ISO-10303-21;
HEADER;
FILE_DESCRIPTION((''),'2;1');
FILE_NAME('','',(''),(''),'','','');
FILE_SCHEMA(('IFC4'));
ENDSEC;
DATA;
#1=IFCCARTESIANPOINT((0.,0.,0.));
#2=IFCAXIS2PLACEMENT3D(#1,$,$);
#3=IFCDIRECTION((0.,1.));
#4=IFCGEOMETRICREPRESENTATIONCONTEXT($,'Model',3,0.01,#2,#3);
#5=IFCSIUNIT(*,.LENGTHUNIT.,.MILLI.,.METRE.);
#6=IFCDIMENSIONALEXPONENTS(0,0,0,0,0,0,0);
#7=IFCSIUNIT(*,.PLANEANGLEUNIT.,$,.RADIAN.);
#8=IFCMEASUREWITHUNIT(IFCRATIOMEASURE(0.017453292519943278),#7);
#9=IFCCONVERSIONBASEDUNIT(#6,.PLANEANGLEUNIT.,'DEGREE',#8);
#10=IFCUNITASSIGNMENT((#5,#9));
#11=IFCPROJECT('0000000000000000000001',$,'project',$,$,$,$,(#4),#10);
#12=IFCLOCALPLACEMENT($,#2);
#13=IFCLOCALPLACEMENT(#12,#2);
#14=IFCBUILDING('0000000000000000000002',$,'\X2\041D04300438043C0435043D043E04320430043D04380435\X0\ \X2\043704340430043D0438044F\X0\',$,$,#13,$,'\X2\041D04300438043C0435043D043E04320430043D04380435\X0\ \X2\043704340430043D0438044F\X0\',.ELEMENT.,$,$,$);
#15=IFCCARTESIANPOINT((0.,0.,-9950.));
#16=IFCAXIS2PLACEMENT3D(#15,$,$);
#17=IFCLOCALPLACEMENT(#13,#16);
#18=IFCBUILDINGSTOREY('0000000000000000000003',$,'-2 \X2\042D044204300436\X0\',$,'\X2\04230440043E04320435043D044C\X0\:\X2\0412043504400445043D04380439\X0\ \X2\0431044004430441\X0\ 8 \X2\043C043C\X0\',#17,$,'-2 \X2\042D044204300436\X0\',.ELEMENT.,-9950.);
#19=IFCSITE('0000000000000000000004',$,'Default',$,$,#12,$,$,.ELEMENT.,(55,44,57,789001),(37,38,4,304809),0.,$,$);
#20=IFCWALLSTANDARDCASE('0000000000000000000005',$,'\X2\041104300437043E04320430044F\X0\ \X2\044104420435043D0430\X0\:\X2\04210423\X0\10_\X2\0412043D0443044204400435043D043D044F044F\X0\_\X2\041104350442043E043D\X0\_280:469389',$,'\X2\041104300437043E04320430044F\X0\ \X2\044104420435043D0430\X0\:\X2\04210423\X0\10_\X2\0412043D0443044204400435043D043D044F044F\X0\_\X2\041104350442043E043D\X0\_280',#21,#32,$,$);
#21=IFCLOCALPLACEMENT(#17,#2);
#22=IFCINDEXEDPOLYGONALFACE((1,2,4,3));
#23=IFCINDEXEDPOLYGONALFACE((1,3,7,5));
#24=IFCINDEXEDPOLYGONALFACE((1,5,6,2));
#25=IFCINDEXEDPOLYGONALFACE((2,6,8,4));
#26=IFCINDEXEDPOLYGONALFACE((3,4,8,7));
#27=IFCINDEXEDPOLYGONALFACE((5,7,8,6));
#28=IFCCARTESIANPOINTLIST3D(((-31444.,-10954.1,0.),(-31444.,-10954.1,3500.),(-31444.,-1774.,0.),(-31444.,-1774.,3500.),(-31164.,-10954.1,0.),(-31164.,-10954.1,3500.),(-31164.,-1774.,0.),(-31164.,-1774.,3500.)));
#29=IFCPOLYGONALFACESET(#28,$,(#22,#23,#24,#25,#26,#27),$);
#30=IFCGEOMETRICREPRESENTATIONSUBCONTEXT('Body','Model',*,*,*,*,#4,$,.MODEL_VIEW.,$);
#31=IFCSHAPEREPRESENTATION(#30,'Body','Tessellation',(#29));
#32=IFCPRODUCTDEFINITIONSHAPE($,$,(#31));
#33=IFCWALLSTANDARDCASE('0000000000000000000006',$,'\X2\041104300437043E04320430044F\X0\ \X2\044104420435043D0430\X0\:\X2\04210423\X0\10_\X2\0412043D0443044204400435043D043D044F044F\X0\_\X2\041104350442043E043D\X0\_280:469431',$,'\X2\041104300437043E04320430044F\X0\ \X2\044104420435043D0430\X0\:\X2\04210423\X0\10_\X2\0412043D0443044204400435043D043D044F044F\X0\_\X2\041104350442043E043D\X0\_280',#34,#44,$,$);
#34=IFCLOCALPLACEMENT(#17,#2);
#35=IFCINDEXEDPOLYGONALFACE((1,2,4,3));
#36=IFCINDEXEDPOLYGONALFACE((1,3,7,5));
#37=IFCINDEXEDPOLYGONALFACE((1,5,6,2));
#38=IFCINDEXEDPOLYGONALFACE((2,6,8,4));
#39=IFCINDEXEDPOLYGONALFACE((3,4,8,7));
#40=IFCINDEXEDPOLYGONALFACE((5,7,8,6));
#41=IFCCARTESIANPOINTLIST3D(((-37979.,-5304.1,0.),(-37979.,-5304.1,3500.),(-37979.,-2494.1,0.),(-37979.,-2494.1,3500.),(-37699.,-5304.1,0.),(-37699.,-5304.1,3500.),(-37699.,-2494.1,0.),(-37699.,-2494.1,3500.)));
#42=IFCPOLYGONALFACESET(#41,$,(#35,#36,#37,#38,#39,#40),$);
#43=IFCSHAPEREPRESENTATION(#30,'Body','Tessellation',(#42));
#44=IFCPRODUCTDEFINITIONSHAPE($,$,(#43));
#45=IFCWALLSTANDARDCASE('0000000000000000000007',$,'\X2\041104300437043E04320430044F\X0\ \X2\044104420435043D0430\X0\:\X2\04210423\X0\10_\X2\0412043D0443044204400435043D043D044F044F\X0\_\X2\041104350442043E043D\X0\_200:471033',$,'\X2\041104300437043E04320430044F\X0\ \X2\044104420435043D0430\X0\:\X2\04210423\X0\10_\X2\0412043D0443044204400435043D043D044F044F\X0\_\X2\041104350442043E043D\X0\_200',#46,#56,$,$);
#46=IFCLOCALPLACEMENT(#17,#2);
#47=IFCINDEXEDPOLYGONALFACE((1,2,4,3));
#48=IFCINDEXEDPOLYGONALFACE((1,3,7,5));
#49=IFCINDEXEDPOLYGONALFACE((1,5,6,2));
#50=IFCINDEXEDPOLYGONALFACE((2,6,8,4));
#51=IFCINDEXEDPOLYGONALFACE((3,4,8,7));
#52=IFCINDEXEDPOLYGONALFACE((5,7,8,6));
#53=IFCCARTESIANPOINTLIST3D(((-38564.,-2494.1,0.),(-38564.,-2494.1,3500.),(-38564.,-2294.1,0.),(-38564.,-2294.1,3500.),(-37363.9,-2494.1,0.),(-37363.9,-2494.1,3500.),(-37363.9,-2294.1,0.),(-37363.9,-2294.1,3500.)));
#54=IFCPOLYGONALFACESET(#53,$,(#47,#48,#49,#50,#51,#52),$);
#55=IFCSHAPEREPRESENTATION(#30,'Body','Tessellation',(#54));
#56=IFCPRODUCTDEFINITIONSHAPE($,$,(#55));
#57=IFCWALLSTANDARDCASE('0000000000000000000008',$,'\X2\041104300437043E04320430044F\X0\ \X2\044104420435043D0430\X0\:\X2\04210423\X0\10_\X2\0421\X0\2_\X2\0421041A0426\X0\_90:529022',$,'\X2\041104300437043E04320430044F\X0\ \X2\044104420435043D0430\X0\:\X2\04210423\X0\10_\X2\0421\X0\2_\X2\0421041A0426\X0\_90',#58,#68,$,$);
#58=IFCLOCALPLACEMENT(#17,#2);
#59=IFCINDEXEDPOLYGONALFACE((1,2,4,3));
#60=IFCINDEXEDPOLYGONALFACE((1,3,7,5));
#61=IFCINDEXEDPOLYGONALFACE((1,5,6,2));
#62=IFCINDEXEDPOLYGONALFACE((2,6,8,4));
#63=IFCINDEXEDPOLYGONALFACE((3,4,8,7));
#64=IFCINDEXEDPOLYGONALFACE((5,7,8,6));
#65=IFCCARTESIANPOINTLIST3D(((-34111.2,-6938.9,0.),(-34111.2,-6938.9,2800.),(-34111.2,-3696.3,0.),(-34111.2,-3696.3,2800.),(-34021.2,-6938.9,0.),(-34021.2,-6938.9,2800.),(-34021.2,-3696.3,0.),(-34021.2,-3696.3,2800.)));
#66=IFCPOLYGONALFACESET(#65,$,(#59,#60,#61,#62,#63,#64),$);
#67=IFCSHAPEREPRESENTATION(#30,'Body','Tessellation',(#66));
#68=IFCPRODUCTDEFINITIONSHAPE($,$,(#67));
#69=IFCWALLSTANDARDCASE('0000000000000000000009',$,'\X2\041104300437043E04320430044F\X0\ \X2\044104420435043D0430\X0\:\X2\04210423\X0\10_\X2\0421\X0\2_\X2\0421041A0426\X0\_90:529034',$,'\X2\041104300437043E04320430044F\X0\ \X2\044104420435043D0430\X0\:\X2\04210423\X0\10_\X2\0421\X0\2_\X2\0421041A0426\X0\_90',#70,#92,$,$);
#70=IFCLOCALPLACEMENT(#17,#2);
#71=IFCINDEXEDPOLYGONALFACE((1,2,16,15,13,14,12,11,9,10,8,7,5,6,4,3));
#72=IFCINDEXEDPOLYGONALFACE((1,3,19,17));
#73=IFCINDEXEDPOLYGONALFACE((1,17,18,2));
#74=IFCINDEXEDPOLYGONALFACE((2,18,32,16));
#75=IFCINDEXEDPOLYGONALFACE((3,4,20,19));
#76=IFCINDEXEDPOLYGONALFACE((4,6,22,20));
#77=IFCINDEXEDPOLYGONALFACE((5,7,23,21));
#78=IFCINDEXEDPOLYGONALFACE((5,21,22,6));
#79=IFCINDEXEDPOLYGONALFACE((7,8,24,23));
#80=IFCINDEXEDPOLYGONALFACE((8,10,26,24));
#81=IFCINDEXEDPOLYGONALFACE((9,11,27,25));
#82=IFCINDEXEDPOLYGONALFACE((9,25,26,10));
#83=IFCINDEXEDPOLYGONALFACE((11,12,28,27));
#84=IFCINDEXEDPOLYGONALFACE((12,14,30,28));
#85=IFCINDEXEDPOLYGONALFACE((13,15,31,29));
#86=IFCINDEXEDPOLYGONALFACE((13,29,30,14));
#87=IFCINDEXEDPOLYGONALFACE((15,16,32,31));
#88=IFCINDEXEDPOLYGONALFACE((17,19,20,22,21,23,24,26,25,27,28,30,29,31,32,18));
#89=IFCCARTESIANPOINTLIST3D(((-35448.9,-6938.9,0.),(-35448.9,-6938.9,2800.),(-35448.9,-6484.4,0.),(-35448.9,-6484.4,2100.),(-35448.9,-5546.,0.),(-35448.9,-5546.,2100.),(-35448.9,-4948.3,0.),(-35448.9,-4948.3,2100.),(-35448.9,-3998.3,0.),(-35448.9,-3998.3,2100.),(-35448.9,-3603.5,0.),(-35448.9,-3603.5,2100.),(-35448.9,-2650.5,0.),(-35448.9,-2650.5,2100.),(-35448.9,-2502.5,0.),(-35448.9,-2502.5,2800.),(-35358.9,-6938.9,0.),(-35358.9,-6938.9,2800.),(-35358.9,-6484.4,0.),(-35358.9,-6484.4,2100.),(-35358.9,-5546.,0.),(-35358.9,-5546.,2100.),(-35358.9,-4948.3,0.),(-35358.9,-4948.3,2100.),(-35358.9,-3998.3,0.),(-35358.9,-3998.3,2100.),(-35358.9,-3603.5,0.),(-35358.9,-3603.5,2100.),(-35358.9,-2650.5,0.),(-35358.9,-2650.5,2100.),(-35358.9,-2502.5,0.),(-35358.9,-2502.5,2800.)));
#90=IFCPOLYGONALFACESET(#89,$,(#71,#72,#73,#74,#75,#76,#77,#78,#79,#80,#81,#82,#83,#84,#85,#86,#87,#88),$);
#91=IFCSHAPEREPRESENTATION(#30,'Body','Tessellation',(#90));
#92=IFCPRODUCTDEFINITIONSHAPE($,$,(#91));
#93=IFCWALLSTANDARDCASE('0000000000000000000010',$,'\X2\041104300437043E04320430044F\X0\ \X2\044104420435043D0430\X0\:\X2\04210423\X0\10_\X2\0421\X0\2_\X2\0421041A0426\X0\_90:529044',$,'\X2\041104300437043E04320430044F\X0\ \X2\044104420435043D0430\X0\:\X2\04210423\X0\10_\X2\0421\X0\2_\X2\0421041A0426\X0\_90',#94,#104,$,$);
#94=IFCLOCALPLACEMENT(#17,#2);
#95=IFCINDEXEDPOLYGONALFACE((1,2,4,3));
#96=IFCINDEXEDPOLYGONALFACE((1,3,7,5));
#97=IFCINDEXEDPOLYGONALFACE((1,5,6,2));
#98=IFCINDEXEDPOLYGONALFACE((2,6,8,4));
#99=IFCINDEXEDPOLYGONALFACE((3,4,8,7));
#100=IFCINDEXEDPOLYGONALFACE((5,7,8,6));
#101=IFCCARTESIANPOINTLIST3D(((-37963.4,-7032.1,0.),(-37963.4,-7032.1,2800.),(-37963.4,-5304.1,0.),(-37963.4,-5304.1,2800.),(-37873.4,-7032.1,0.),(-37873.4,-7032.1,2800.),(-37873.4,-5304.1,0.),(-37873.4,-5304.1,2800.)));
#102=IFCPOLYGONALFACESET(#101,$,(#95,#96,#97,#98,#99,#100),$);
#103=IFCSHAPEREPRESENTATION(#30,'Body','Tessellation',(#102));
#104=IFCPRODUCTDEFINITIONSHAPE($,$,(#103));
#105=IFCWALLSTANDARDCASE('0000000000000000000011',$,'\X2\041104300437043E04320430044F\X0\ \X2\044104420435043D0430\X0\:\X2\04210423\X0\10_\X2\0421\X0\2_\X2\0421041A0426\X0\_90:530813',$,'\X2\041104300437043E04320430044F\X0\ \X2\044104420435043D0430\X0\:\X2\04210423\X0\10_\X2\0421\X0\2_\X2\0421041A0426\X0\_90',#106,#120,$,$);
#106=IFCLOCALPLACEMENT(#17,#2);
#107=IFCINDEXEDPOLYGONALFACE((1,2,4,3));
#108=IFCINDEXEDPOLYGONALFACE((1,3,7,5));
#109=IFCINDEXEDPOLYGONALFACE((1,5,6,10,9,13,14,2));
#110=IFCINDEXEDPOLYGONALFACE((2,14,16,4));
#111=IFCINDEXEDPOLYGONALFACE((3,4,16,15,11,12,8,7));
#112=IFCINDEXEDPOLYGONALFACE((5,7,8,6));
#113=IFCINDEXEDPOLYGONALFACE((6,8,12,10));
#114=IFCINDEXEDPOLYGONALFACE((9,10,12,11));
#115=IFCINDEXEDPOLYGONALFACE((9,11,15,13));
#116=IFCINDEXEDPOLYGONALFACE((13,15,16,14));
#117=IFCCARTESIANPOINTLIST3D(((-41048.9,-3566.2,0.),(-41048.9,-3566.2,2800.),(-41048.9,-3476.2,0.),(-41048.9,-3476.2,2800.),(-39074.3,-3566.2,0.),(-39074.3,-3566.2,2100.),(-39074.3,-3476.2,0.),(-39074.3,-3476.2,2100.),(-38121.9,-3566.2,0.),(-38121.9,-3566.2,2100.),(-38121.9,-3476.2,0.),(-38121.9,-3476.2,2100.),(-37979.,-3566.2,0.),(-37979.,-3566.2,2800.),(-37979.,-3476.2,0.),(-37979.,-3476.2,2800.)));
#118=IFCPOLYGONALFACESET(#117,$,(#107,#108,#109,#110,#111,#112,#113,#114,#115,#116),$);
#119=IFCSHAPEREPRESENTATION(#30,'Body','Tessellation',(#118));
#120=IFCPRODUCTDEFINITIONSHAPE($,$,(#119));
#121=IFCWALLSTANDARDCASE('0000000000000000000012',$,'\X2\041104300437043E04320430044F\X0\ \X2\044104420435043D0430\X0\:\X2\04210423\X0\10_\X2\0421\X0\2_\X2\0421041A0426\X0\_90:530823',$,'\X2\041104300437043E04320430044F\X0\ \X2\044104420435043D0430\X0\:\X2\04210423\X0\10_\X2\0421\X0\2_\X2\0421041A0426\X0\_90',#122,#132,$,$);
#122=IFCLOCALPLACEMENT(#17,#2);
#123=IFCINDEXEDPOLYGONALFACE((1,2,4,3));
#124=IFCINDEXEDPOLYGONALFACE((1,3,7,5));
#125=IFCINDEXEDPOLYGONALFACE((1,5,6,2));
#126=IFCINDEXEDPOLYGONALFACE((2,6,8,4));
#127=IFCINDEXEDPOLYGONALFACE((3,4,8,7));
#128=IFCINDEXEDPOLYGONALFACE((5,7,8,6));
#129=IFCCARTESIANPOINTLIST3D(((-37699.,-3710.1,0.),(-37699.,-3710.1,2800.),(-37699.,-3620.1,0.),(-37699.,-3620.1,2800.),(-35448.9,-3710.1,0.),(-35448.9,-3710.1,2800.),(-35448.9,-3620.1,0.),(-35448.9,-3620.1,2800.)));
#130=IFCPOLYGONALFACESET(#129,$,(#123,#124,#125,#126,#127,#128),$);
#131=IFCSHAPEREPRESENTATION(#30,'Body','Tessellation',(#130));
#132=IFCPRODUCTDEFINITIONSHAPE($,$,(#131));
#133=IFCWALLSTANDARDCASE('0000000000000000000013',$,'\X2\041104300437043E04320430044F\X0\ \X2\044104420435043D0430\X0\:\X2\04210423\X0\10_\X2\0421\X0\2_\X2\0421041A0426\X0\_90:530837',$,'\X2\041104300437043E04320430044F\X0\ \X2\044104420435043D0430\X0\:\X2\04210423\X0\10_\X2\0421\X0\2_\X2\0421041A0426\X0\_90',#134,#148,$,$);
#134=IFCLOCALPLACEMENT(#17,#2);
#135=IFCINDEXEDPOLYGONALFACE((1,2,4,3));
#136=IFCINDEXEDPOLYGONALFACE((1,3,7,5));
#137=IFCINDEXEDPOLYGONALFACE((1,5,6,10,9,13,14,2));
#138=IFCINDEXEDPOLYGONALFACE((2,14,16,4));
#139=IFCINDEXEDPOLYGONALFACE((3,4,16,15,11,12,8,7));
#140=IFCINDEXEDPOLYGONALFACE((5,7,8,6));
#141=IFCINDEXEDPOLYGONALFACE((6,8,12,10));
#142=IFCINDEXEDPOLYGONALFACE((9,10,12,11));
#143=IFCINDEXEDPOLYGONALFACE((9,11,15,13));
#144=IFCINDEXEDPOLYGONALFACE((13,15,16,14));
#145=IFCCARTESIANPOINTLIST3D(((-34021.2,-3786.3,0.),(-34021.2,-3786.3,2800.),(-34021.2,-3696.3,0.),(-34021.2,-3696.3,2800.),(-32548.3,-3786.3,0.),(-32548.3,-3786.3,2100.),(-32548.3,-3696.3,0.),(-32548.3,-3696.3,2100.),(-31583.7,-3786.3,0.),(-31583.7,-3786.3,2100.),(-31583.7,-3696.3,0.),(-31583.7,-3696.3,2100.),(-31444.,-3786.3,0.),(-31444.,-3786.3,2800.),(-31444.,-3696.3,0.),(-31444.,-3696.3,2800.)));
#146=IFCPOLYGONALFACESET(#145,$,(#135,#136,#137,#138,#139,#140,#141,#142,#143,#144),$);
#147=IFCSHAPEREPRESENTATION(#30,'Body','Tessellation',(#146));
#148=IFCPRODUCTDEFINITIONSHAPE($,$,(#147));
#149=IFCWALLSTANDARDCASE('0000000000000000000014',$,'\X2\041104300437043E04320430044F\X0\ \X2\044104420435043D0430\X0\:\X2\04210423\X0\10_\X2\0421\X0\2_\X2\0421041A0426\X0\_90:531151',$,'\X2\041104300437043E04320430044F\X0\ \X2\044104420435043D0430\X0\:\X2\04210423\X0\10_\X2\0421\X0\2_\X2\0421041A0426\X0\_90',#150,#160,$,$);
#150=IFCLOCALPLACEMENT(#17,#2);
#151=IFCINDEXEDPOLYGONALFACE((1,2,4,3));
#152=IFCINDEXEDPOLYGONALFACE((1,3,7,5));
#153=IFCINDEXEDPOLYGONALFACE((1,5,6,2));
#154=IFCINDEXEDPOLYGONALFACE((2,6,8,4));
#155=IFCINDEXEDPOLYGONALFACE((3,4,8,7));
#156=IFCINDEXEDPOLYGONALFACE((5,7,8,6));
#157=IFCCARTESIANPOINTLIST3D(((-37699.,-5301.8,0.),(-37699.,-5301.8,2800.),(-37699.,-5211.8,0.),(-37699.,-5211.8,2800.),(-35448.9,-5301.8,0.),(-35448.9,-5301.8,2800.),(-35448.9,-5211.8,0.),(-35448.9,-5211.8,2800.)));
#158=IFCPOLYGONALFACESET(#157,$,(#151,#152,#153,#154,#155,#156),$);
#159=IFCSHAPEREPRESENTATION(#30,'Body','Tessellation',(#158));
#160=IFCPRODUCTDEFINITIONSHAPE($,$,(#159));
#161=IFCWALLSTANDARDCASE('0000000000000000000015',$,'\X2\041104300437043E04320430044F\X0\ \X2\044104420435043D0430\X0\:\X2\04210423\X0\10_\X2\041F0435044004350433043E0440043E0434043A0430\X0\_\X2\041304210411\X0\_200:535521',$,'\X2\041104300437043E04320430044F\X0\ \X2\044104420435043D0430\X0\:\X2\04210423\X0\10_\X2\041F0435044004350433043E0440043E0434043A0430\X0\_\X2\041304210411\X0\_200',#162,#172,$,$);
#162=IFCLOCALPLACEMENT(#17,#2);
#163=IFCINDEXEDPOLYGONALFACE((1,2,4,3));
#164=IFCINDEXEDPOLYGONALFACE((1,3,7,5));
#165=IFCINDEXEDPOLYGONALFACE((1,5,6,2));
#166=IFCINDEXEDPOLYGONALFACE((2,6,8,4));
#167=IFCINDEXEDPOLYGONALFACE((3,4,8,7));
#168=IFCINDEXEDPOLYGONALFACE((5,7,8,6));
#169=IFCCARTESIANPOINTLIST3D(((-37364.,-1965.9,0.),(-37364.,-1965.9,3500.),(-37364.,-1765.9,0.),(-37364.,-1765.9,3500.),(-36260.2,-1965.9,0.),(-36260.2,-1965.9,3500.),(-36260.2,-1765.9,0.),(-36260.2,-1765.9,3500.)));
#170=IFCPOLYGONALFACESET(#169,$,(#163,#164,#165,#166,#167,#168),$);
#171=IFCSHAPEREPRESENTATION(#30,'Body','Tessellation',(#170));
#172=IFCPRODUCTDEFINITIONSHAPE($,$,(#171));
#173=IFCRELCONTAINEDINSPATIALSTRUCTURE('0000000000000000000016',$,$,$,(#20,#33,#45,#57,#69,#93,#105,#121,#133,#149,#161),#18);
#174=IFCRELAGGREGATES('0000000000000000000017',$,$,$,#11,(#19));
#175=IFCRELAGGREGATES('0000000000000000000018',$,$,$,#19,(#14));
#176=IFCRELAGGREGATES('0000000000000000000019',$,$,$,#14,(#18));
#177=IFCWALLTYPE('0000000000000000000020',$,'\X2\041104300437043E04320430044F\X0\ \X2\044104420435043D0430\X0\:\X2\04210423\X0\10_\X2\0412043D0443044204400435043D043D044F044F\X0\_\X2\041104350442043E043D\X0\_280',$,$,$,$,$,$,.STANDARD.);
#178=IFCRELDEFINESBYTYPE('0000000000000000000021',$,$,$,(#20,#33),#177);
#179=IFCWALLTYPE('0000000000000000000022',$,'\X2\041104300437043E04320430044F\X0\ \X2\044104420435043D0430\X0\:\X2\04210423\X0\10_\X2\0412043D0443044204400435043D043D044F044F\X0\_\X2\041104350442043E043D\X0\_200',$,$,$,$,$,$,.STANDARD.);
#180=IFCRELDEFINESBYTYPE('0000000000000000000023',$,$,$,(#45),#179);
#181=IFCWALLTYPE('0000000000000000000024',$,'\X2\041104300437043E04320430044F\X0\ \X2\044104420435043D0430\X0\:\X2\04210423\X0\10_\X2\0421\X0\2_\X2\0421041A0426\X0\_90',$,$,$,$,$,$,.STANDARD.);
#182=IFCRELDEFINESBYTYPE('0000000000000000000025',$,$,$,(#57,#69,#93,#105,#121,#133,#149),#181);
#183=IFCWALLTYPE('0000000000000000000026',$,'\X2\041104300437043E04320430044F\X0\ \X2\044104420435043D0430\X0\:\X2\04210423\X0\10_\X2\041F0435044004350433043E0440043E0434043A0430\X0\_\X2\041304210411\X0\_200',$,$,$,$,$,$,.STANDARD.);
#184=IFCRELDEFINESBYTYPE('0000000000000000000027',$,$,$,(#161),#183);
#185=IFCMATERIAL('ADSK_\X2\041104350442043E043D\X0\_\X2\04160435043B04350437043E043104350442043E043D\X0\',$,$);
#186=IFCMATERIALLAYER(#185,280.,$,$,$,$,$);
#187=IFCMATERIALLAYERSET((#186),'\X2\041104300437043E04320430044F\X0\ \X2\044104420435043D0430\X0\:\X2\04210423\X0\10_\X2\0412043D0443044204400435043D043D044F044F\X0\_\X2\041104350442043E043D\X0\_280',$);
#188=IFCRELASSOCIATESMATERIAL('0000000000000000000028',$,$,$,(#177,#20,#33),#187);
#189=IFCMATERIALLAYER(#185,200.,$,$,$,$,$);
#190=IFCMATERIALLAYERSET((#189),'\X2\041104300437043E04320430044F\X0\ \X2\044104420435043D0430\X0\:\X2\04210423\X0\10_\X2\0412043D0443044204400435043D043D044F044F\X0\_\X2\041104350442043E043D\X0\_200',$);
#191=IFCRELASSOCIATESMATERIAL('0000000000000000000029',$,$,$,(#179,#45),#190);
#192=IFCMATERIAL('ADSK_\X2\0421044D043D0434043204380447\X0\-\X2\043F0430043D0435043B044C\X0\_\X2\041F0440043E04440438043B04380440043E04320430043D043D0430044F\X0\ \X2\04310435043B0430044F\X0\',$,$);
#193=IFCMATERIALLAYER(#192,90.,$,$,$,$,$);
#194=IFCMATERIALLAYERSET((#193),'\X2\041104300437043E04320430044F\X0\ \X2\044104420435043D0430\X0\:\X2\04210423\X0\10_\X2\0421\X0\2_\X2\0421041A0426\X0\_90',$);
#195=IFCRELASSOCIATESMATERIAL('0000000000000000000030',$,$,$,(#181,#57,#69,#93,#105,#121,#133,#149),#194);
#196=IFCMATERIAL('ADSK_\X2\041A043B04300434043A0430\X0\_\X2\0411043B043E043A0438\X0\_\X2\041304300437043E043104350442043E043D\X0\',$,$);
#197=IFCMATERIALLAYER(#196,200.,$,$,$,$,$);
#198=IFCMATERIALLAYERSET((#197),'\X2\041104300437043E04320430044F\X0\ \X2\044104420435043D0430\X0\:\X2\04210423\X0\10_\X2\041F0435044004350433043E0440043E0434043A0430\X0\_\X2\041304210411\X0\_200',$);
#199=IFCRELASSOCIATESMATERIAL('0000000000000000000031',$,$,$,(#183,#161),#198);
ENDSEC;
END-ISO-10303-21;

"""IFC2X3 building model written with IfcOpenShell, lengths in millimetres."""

from ifc_helpers import new_model, entity, si_unit, converted_unit, direction, frame, frame_2d, origin, place, context, subcontext, project, spatial, rectangle, extrude, material, layer, layer_set, layer_usage, type_object, element, save


model = new_model("IFC2X3")

# Units and contexts
model_context = context("Model", 3, precision=0.01, world=origin(), true_north=direction((0.0, 1.0)))
body_context = subcontext(model_context, "Body", "Model", "MODEL_VIEW")
ifc_project = project(units=[si_unit("LENGTHUNIT", "METRE", prefix="MILLI"), converted_unit("PLANEANGLEUNIT", "DEGREE", entity("IfcRatioMeasure", 0.017453292519943278), si_unit("PLANEANGLEUNIT", "RADIAN"), dimensions=[0, 0, 0, 0, 0, 0, 0])], contexts=[model_context])

# Site, building, storey
site_placement = place(None, origin())
site = spatial("IfcSite", under=ifc_project, at=site_placement, Name="Default", CompositionType="ELEMENT", RefLatitude=(55, 44, 57, 789001), RefLongitude=(37, 38, 4, 304809), RefElevation=0.0)
building_placement = place(site_placement, origin())
building = spatial("IfcBuilding", under=site, at=building_placement, Name="Наименование здания", LongName="Наименование здания", CompositionType="ELEMENT")
storey_placement = place(building_placement, frame((0.0, 0.0, -9950.0)))
storey = spatial("IfcBuildingStorey", under=building, at=storey_placement, Name="-2 Этаж", ObjectType="Уровень:Верхний брус 8 мм", LongName="-2 Этаж", CompositionType="ELEMENT", Elevation=-9950.0)

# Walls
ifc_material_1 = material(Name="ADSK_Бетон_Железобетон")
ifc_layer_1 = layer(ifc_material_1, 280.0)
ifc_layer_set_1 = layer_set([ifc_layer_1], Name="Базовая стена:СУ10_Внутренняя_Бетон_280")
ifc_layer_usage_1 = layer_usage(ifc_layer_set_1, "AXIS2", "NEGATIVE", 140.0)
wall_type_1 = type_object("IfcWallType", Name="Базовая стена:СУ10_Внутренняя_Бетон_280", PredefinedType="STANDARD", material=ifc_layer_set_1)
wall_1_placement = place(storey_placement, frame((-31304.0, -1774.0, 0.0), z_axis=(0.0, 0.0, 1.0), x_axis=(0.0, -1.0, 0.0)))
element("IfcWallStandardCase", 1, at=wall_1_placement, inside=storey, type_object=wall_type_1, material=ifc_layer_usage_1, Name="Базовая стена:СУ10_Внутренняя_Бетон_280:469389", ObjectType="Базовая стена:СУ10_Внутренняя_Бетон_280", context=body_context, shape_type="SweptSolid", body=[
    extrude(rectangle(XDim=9180.0, YDim=280.0, at=frame_2d((4590.0, 0.0), x_axis=(-1.0, 0.0))), origin(), (0.0, 0.0, 1.0), 3500.0),
])
wall_2_placement = place(storey_placement, frame((-37839.0, -2494.1, 0.0), z_axis=(0.0, 0.0, 1.0), x_axis=(0.0, -1.0, 0.0)))
element("IfcWallStandardCase", 2, at=wall_2_placement, inside=storey, type_object=wall_type_1, material=ifc_layer_usage_1, Name="Базовая стена:СУ10_Внутренняя_Бетон_280:469431", ObjectType="Базовая стена:СУ10_Внутренняя_Бетон_280", context=body_context, shape_type="SweptSolid", body=[
    extrude(rectangle(XDim=2810.0, YDim=280.0, at=frame_2d((1405.0, 0.0), x_axis=(-1.0, 0.0))), origin(), (0.0, 0.0, 1.0), 3500.0),
])
ifc_layer_2 = layer(ifc_material_1, 200.0)
ifc_layer_set_2 = layer_set([ifc_layer_2], Name="Базовая стена:СУ10_Внутренняя_Бетон_200")
ifc_layer_usage_2 = layer_usage(ifc_layer_set_2, "AXIS2", "NEGATIVE", 100.0)
wall_type_2 = type_object("IfcWallType", Name="Базовая стена:СУ10_Внутренняя_Бетон_200", PredefinedType="STANDARD", material=ifc_layer_set_2)
wall_3_placement = place(storey_placement, frame((-37363.9, -2394.1, 0.0), z_axis=(0.0, 0.0, 1.0), x_axis=(-1.0, 0.0, 0.0)))
element("IfcWallStandardCase", 3, at=wall_3_placement, inside=storey, type_object=wall_type_2, material=ifc_layer_usage_2, Name="Базовая стена:СУ10_Внутренняя_Бетон_200:471033", ObjectType="Базовая стена:СУ10_Внутренняя_Бетон_200", context=body_context, shape_type="SweptSolid", body=[
    extrude(rectangle(XDim=1200.1, YDim=200.0, at=frame_2d((600.1, 0.0), x_axis=(-1.0, 0.0))), origin(), (0.0, 0.0, 1.0), 3500.0),
])
ifc_material_2 = material(Name="ADSK_Сэндвич-панель_Профилированная белая")
ifc_layer_3 = layer(ifc_material_2, 90.0)
ifc_layer_set_3 = layer_set([ifc_layer_3], Name="Базовая стена:СУ10_С2_СКЦ_90")
ifc_layer_usage_3 = layer_usage(ifc_layer_set_3, "AXIS2", "NEGATIVE", 45.0)
wall_type_3 = type_object("IfcWallType", Name="Базовая стена:СУ10_С2_СКЦ_90", PredefinedType="STANDARD", material=ifc_layer_set_3)
wall_4_placement = place(storey_placement, frame((-34066.2, -3696.3, 0.0), z_axis=(0.0, 0.0, 1.0), x_axis=(0.0, -1.0, 0.0)))
element("IfcWallStandardCase", 4, at=wall_4_placement, inside=storey, type_object=wall_type_3, material=ifc_layer_usage_3, Name="Базовая стена:СУ10_С2_СКЦ_90:529022", ObjectType="Базовая стена:СУ10_С2_СКЦ_90", context=body_context, shape_type="SweptSolid", body=[
    extrude(rectangle(XDim=3242.6, YDim=90.0, at=frame_2d((1621.3, 0.0), x_axis=(-1.0, 0.0))), origin(), (0.0, 0.0, 1.0), 2800.0),
])

# Wall, openings
wall_5_placement = place(storey_placement, frame((-35403.9, -2502.5, 0.0), z_axis=(0.0, 0.0, 1.0), x_axis=(0.0, -1.0, 0.0)))
wall_5 = element("IfcWallStandardCase", 5, at=wall_5_placement, inside=storey, type_object=wall_type_3, material=ifc_layer_usage_3, Name="Базовая стена:СУ10_С2_СКЦ_90:529034", ObjectType="Базовая стена:СУ10_С2_СКЦ_90", context=body_context, shape_type="SweptSolid", body=[
    extrude(rectangle(XDim=4436.4, YDim=90.0, at=frame_2d((2218.2, 0.0), x_axis=(1.0, 0.0))), origin(), (0.0, 0.0, 1.0), 2800.0),
])
opening_1_placement = place(wall_5_placement, origin())
element("IfcOpeningElement", 6, at=opening_1_placement, cuts=wall_5, ObjectType="Opening", context=body_context, shape_type="SweptSolid", body=[
    extrude(rectangle(XDim=2100.0, YDim=953.0, at=frame_2d((0.0, 0.0), x_axis=(1.0, 0.0))), frame((624.5, -45.0, 1050.0), z_axis=(0.0, 1.0, 0.0), x_axis=(0.0, 0.0, -1.0)), (0.0, 0.0, 1.0), 90.0),
])
opening_2_placement = place(wall_5_placement, origin())
element("IfcOpeningElement", 7, at=opening_2_placement, cuts=wall_5, ObjectType="Opening", context=body_context, shape_type="SweptSolid", body=[
    extrude(rectangle(XDim=2100.0, YDim=950.0, at=frame_2d((0.0, 0.0), x_axis=(1.0, 0.0))), frame((1970.7, -45.0, 1050.0), z_axis=(0.0, 1.0, 0.0), x_axis=(0.0, 0.0, -1.0)), (0.0, 0.0, 1.0), 90.0),
])
opening_3_placement = place(wall_5_placement, origin())
element("IfcOpeningElement", 8, at=opening_3_placement, cuts=wall_5, ObjectType="Opening", context=body_context, shape_type="SweptSolid", body=[
    extrude(rectangle(XDim=2100.0, YDim=938.5, at=frame_2d((0.0, 0.0), x_axis=(1.0, 0.0))), frame((3512.7, -45.0, 1050.0), z_axis=(0.0, 1.0, 0.0), x_axis=(0.0, 0.0, -1.0)), (0.0, 0.0, 1.0), 90.0),
])

# Wall
wall_6_placement = place(storey_placement, frame((-37918.4, -5304.1, 0.0), z_axis=(0.0, 0.0, 1.0), x_axis=(0.0, -1.0, 0.0)))
element("IfcWallStandardCase", 9, at=wall_6_placement, inside=storey, type_object=wall_type_3, material=ifc_layer_usage_3, Name="Базовая стена:СУ10_С2_СКЦ_90:529044", ObjectType="Базовая стена:СУ10_С2_СКЦ_90", context=body_context, shape_type="SweptSolid", body=[
    extrude(rectangle(XDim=1728.0, YDim=90.0, at=frame_2d((864.0, 0.0), x_axis=(-1.0, 0.0))), origin(), (0.0, 0.0, 1.0), 2800.0),
])

# Wall, opening
wall_7_placement = place(storey_placement, frame((-37979.0, -3521.2, 0.0), z_axis=(0.0, 0.0, 1.0), x_axis=(-1.0, 0.0, 0.0)))
wall_7 = element("IfcWallStandardCase", 10, at=wall_7_placement, inside=storey, type_object=wall_type_3, material=ifc_layer_usage_3, Name="Базовая стена:СУ10_С2_СКЦ_90:530813", ObjectType="Базовая стена:СУ10_С2_СКЦ_90", context=body_context, shape_type="SweptSolid", body=[
    extrude(rectangle(XDim=3069.9, YDim=90.0, at=frame_2d((1534.9, 0.0), x_axis=(1.0, 0.0))), origin(), (0.0, 0.0, 1.0), 2800.0),
])
opening_4_placement = place(wall_7_placement, origin())
element("IfcOpeningElement", 11, at=opening_4_placement, cuts=wall_7, ObjectType="Opening", context=body_context, shape_type="SweptSolid", body=[
    extrude(rectangle(XDim=2100.0, YDim=952.4, at=frame_2d((0.0, 0.0), x_axis=(1.0, 0.0))), frame((619.1, -45.0, 1050.0), z_axis=(0.0, 1.0, 0.0), x_axis=(0.0, 0.0, -1.0)), (0.0, 0.0, 1.0), 90.0),
])

# Wall
wall_8_placement = place(storey_placement, frame((-35448.9, -3665.1, 0.0), z_axis=(0.0, 0.0, 1.0), x_axis=(-1.0, 0.0, 0.0)))
element("IfcWallStandardCase", 12, at=wall_8_placement, inside=storey, type_object=wall_type_3, material=ifc_layer_usage_3, Name="Базовая стена:СУ10_С2_СКЦ_90:530823", ObjectType="Базовая стена:СУ10_С2_СКЦ_90", context=body_context, shape_type="SweptSolid", body=[
    extrude(rectangle(XDim=2250.2, YDim=90.0, at=frame_2d((1125.1, 0.0), x_axis=(-1.0, 0.0))), origin(), (0.0, 0.0, 1.0), 2800.0),
])

# Wall, opening
wall_9_placement = place(storey_placement, frame((-31444.0, -3741.3, 0.0), z_axis=(0.0, 0.0, 1.0), x_axis=(-1.0, 0.0, 0.0)))
wall_9 = element("IfcWallStandardCase", 13, at=wall_9_placement, inside=storey, type_object=wall_type_3, material=ifc_layer_usage_3, Name="Базовая стена:СУ10_С2_СКЦ_90:530837", ObjectType="Базовая стена:СУ10_С2_СКЦ_90", context=body_context, shape_type="SweptSolid", body=[
    extrude(rectangle(XDim=2577.2, YDim=90.0, at=frame_2d((1288.6, 0.0), x_axis=(1.0, 0.0))), origin(), (0.0, 0.0, 1.0), 2800.0),
])
opening_5_placement = place(wall_9_placement, origin())
element("IfcOpeningElement", 14, at=opening_5_placement, cuts=wall_9, ObjectType="Opening", context=body_context, shape_type="SweptSolid", body=[
    extrude(rectangle(XDim=2100.0, YDim=964.6, at=frame_2d((0.0, 0.0), x_axis=(1.0, 0.0))), frame((622.0, -45.0, 1050.0), z_axis=(0.0, 1.0, 0.0), x_axis=(0.0, 0.0, -1.0)), (0.0, 0.0, 1.0), 90.0),
])

# Walls
wall_10_placement = place(storey_placement, frame((-35448.9, -5256.8, 0.0), z_axis=(0.0, 0.0, 1.0), x_axis=(-1.0, 0.0, 0.0)))
element("IfcWallStandardCase", 15, at=wall_10_placement, inside=storey, type_object=wall_type_3, material=ifc_layer_usage_3, Name="Базовая стена:СУ10_С2_СКЦ_90:531151", ObjectType="Базовая стена:СУ10_С2_СКЦ_90", context=body_context, shape_type="SweptSolid", body=[
    extrude(rectangle(XDim=2250.2, YDim=90.0, at=frame_2d((1125.1, 0.0), x_axis=(-1.0, 0.0))), origin(), (0.0, 0.0, 1.0), 2800.0),
])
ifc_material_3 = material(Name="ADSK_Кладка_Блоки_Газобетон")
ifc_layer_4 = layer(ifc_material_3, 200.0)
ifc_layer_set_4 = layer_set([ifc_layer_4], Name="Базовая стена:СУ10_Перегородка_ГСБ_200")
ifc_layer_usage_4 = layer_usage(ifc_layer_set_4, "AXIS2", "NEGATIVE", 100.0)
wall_type_4 = type_object("IfcWallType", Name="Базовая стена:СУ10_Перегородка_ГСБ_200", PredefinedType="STANDARD", material=ifc_layer_set_4)
wall_11_placement = place(storey_placement, frame((-36260.2, -1865.9, 0.0), z_axis=(0.0, 0.0, 1.0), x_axis=(-1.0, 0.0, 0.0)))
element("IfcWallStandardCase", 16, at=wall_11_placement, inside=storey, type_object=wall_type_4, material=ifc_layer_usage_4, Name="Базовая стена:СУ10_Перегородка_ГСБ_200:535521", ObjectType="Базовая стена:СУ10_Перегородка_ГСБ_200", context=body_context, shape_type="SweptSolid", body=[
    extrude(rectangle(XDim=1103.8, YDim=200.0, at=frame_2d((551.9, 0.0), x_axis=(-1.0, 0.0))), origin(), (0.0, 0.0, 1.0), 3500.0),
])

save(model, "model.ifc")
